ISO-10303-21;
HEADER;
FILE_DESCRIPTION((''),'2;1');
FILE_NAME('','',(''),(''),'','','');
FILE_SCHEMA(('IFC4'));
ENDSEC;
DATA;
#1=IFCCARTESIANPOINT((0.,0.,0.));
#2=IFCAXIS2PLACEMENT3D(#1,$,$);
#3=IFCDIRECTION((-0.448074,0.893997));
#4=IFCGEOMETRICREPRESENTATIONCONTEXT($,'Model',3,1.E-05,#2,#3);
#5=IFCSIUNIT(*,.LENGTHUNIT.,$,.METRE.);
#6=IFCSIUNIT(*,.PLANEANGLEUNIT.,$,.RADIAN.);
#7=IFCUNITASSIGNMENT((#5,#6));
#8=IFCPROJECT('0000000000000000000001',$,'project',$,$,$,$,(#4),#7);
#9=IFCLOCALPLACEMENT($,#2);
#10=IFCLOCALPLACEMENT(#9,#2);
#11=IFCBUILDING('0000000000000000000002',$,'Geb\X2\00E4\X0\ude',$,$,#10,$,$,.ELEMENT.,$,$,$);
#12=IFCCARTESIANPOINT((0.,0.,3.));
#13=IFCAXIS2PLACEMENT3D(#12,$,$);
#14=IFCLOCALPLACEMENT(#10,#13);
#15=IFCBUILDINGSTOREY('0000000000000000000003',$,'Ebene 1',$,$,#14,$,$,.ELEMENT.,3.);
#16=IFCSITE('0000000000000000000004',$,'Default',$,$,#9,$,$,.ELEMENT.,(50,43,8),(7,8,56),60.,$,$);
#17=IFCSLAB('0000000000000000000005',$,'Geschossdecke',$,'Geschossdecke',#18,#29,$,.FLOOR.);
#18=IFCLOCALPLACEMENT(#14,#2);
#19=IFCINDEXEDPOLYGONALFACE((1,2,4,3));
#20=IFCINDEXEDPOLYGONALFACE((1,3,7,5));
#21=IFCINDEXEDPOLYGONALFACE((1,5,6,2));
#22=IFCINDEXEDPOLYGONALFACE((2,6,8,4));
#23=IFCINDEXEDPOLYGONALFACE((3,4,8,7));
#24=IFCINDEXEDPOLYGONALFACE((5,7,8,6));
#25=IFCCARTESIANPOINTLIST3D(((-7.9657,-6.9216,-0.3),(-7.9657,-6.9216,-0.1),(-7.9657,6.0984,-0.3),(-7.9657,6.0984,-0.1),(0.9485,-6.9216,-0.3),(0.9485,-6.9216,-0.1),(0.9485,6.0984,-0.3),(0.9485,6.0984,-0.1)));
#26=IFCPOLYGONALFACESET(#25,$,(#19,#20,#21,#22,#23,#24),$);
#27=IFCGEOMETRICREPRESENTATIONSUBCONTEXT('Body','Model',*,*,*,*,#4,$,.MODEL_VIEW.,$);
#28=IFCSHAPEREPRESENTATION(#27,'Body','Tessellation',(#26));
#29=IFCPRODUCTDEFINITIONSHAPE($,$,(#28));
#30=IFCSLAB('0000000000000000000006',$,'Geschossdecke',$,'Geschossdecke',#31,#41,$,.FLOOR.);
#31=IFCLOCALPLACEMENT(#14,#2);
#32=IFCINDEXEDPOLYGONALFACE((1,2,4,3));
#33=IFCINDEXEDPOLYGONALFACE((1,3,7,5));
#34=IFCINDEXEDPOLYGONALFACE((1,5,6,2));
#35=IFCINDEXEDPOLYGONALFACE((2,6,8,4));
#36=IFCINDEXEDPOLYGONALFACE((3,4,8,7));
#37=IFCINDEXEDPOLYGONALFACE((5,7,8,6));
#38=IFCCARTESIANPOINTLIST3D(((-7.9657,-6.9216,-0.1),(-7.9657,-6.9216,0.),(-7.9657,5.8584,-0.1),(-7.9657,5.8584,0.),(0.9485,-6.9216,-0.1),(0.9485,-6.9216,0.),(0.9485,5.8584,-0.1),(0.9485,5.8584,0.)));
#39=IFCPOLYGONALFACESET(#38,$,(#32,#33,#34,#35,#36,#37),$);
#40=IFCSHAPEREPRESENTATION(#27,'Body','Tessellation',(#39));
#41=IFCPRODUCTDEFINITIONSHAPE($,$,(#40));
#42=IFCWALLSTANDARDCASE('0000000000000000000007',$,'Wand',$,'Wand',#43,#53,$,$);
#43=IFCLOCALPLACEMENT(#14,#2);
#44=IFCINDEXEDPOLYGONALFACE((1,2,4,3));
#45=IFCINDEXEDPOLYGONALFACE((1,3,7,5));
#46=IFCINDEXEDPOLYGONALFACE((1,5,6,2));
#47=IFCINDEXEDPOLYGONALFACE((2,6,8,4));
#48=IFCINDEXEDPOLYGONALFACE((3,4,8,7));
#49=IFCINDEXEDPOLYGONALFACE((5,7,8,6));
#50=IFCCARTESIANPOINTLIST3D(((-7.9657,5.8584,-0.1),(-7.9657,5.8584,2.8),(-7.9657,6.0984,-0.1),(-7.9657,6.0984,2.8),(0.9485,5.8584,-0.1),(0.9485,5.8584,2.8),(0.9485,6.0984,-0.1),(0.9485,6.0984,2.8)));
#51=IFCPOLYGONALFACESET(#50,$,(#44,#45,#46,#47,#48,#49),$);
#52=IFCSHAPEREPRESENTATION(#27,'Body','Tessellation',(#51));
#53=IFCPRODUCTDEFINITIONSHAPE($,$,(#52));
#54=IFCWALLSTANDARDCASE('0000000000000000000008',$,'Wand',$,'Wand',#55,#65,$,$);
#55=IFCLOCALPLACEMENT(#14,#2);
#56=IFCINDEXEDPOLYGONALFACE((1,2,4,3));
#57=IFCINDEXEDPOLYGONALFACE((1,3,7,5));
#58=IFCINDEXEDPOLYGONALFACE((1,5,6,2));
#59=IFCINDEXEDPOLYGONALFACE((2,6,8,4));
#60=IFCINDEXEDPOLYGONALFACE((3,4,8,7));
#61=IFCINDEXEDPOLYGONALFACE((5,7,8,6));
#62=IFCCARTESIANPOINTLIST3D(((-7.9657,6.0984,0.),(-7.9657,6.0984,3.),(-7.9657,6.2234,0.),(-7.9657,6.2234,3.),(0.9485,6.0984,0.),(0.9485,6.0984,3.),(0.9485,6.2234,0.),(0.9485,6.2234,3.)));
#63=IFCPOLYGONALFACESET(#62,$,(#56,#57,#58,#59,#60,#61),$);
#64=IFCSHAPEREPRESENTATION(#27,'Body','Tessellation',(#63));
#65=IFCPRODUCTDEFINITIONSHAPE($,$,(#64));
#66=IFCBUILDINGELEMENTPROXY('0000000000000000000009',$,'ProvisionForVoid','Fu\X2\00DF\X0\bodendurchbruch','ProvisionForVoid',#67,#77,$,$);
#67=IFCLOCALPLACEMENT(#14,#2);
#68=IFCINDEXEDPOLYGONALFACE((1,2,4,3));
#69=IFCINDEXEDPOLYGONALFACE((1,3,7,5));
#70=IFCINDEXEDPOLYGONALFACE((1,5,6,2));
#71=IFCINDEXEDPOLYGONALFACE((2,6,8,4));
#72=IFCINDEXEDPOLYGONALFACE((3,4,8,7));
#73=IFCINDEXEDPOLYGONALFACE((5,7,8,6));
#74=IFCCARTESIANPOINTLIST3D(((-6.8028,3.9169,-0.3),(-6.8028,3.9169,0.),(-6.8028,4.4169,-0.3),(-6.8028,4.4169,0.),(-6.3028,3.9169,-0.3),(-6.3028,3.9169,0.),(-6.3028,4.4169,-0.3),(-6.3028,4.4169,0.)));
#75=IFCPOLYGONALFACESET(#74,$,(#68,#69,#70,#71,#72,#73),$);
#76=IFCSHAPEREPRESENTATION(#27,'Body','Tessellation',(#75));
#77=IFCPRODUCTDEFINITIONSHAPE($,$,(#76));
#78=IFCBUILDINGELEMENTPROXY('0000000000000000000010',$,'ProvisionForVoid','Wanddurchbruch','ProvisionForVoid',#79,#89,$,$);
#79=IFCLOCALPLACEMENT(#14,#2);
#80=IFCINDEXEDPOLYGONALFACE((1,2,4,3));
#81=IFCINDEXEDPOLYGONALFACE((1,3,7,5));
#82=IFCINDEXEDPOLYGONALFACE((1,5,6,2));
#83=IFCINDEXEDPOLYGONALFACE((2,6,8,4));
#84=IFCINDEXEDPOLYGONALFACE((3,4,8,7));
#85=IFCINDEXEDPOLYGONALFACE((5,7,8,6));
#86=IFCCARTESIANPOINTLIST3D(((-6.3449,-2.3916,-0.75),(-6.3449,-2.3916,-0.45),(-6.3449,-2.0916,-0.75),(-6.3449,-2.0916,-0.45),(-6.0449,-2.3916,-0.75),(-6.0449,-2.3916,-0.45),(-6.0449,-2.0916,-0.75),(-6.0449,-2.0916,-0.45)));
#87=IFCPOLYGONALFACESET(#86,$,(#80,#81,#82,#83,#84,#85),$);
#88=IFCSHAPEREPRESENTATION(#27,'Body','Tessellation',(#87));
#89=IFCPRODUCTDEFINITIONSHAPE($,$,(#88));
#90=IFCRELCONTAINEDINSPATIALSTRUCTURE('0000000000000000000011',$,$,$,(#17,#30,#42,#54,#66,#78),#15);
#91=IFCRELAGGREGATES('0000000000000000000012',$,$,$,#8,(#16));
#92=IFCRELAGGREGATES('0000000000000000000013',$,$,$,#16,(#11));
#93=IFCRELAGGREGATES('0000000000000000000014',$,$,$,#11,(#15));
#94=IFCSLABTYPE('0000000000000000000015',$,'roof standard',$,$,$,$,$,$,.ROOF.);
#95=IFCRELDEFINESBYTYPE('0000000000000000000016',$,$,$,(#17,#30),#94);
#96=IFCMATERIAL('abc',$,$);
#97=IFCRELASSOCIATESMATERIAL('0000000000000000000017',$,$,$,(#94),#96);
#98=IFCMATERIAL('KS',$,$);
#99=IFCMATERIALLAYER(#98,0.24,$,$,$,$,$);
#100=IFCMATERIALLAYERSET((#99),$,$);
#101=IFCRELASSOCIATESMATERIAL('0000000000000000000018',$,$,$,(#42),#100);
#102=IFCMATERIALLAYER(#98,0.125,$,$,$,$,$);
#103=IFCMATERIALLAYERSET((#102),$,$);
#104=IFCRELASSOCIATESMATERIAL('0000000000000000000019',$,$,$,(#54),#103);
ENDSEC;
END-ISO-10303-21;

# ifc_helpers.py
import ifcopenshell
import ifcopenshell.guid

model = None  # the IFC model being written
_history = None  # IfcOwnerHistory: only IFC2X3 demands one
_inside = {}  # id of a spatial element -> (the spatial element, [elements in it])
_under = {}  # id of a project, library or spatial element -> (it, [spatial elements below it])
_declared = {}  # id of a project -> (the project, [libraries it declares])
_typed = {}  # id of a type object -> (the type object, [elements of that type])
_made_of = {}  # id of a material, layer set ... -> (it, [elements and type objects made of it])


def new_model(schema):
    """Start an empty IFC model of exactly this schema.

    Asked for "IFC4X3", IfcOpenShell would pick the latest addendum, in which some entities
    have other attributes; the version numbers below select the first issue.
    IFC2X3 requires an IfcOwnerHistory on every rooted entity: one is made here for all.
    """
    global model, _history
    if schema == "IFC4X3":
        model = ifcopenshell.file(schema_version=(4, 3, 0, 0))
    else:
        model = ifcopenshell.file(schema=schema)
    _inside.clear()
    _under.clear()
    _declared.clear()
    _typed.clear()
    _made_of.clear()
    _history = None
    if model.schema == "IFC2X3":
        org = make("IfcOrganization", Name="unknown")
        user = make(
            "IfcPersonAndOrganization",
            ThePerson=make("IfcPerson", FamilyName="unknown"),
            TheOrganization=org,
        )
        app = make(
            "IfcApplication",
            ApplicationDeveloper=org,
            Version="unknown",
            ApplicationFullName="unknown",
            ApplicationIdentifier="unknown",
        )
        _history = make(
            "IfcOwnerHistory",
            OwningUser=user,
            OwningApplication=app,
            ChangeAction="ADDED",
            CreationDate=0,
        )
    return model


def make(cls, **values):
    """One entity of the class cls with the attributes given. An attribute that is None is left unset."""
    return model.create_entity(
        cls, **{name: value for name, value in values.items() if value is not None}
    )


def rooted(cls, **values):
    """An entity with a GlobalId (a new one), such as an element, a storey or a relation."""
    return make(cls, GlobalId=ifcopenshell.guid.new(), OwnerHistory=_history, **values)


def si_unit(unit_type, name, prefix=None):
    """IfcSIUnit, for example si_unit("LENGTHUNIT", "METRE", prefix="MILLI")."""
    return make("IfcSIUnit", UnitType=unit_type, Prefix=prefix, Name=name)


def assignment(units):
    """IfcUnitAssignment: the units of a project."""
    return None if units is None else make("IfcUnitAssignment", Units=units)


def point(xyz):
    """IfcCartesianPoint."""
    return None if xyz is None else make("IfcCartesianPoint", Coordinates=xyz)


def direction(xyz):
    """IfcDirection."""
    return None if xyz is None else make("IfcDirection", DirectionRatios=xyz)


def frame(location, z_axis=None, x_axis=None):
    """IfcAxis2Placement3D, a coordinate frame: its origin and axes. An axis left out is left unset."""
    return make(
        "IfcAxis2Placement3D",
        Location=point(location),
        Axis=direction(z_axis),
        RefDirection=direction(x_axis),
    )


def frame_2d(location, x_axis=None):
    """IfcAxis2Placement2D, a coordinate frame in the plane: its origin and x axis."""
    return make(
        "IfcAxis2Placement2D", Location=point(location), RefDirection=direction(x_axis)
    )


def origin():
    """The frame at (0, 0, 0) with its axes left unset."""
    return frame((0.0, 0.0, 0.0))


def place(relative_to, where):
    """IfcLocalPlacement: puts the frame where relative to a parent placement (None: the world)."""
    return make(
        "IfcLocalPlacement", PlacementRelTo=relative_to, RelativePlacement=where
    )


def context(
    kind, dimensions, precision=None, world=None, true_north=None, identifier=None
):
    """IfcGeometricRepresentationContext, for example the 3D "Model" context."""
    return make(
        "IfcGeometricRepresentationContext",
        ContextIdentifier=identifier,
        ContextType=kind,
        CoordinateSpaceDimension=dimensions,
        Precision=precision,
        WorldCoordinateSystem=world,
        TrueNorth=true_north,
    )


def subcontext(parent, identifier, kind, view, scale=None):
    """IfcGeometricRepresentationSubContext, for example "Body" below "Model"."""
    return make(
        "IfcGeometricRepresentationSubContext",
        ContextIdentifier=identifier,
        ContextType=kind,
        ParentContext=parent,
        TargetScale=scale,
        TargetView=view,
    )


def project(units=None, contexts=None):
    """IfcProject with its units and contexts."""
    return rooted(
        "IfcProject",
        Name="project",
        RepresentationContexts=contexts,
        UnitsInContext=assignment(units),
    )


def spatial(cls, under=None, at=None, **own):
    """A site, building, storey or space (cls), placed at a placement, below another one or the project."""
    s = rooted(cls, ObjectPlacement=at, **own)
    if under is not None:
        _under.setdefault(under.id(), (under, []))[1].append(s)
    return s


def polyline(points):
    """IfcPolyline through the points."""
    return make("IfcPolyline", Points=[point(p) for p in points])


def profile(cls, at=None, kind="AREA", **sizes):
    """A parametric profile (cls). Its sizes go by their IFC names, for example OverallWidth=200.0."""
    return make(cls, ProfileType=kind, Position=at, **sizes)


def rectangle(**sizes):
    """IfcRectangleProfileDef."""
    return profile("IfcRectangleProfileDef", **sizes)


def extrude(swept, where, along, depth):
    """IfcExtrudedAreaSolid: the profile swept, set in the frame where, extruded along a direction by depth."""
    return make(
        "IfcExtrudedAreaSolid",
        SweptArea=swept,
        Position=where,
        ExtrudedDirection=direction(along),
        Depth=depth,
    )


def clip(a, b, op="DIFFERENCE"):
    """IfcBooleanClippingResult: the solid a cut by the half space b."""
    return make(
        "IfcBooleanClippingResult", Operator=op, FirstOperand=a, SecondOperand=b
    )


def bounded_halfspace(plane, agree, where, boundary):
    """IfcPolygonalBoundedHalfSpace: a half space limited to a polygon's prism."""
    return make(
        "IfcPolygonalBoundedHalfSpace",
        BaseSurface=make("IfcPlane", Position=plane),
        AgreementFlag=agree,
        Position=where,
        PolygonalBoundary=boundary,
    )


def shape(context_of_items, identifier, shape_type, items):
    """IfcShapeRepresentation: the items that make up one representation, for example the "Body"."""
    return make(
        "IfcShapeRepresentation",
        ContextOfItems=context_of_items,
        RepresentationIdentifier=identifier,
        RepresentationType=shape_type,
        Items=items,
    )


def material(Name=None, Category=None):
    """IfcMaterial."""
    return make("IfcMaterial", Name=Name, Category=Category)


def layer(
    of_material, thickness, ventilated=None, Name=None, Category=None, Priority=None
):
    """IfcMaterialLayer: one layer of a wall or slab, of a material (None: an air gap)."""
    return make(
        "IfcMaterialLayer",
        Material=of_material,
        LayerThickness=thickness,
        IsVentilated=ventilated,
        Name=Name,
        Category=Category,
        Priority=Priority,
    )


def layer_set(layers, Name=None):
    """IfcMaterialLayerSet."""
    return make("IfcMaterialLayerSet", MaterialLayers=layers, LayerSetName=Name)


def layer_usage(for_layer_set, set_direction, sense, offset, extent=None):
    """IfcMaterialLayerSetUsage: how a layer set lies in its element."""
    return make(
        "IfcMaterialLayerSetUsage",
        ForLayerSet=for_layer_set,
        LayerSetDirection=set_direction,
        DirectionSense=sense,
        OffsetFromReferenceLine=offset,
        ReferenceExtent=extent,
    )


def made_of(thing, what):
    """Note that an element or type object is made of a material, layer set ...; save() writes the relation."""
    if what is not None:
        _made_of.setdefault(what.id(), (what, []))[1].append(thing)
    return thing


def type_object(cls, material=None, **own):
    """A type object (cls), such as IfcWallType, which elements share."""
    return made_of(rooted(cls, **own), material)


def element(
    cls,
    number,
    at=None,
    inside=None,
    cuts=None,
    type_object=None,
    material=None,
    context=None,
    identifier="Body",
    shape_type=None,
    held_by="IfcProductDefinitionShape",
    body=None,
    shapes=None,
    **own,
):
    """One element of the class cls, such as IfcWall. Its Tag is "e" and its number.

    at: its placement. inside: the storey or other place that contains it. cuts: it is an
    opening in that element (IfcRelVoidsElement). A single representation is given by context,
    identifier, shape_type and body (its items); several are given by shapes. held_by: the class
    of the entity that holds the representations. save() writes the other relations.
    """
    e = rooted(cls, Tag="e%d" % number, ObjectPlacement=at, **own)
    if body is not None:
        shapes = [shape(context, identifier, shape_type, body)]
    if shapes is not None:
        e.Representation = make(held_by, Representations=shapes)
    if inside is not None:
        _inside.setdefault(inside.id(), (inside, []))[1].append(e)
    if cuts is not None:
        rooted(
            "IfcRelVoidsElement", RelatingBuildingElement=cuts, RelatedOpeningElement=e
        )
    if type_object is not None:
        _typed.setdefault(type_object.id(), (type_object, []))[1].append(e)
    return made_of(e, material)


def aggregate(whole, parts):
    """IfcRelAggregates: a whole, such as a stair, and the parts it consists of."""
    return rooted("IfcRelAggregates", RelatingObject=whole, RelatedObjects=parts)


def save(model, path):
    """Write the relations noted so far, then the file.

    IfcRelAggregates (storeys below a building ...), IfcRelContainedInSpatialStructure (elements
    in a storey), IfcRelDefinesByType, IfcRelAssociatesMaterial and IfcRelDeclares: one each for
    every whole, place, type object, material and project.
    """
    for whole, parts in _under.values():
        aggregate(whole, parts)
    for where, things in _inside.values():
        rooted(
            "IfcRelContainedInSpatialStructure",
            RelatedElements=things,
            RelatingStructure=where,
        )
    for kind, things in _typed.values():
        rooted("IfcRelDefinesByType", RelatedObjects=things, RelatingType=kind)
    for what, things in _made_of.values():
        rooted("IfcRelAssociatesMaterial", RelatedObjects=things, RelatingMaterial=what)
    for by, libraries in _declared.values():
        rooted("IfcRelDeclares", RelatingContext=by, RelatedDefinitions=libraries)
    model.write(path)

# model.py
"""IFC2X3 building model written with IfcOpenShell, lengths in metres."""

from ifc_helpers import new_model, si_unit, direction, frame, frame_2d, origin, place, context, subcontext, project, spatial, polyline, rectangle, extrude, clip, bounded_halfspace, material, layer, layer_set, layer_usage, type_object, element, save


model = new_model("IFC2X3")

# Units and contexts
model_context = context("Model", 3, precision=1e-05, world=origin(), true_north=direction((-0.448074, 0.893997)))
body_context = subcontext(model_context, "Body", "Model", "MODEL_VIEW")
ifc_project = project(units=[si_unit("LENGTHUNIT", "METRE"), si_unit("PLANEANGLEUNIT", "RADIAN")], contexts=[model_context])

# Site, building, storey
site_placement = place(None, origin())
site = spatial("IfcSite", under=ifc_project, at=site_placement, Name="Default", CompositionType="ELEMENT", RefLatitude=(50, 43, 8), RefLongitude=(7, 8, 56), RefElevation=60.0)
building_placement = place(site_placement, origin())
building = spatial("IfcBuilding", under=site, at=building_placement, Name="Gebäude", CompositionType="ELEMENT")
storey_placement = place(building_placement, frame((0.0, 0.0, 3.0)))
storey = spatial("IfcBuildingStorey", under=building, at=storey_placement, Name="Ebene 1", CompositionType="ELEMENT", Elevation=3.0)

# Slabs
ifc_material_1 = material(Name="abc")
slab_type = type_object("IfcSlabType", Name="roof standard", PredefinedType="ROOF", material=ifc_material_1)
slab_1_placement = place(storey_placement, frame((0.0, 0.0, -0.1)))
element("IfcSlab", 1, at=slab_1_placement, inside=storey, type_object=slab_type, Name="Geschossdecke", ObjectType="Geschossdecke", PredefinedType="FLOOR", context=body_context, shape_type="SweptSolid", body=[
    extrude(rectangle(XDim=8.9141, YDim=13.02, at=frame_2d((0.0, 0.0), x_axis=(1.0, 0.0))), frame((-3.5086, -0.4116, -0.2)), (0.0, 0.0, 1.0), 0.2),
])
slab_2_placement = place(storey_placement, origin())
element("IfcSlab", 2, at=slab_2_placement, inside=storey, type_object=slab_type, Name="Geschossdecke", ObjectType="Geschossdecke", PredefinedType="FLOOR", context=body_context, shape_type="SweptSolid", body=[
    extrude(rectangle(XDim=8.9141, YDim=12.78, at=frame_2d((0.0, 0.0), x_axis=(1.0, 0.0))), frame((-3.5086, -0.5316, -0.1)), (0.0, 0.0, 1.0), 0.1),
])

# Walls
ifc_material_2 = material(Name="KS")
ifc_layer_1 = layer(ifc_material_2, 0.24)
ifc_layer_set_1 = layer_set([ifc_layer_1])
ifc_layer_usage_1 = layer_usage(ifc_layer_set_1, "AXIS2", "POSITIVE", -0.12)
wall_1_placement = place(storey_placement, frame((-7.9657, 5.9784, 0.0)))
element("IfcWallStandardCase", 3, at=wall_1_placement, inside=storey, material=ifc_layer_usage_1, Name="Wand", ObjectType="Wand", context=body_context, shape_type="Clipping", body=[
    clip(clip(extrude(rectangle(XDim=8.9141, YDim=0.24, at=frame_2d((0.0, 0.0), x_axis=(1.0, 0.0))), frame((4.4571, 0.0, -0.1)), (0.0, 0.0, 1.0), 2.9), bounded_halfspace(frame((0.0, -0.12, 2.8)), False, origin(), polyline([(0.0, -0.12), (8.9141, -0.12), (8.9141, 0.12), (0.0, 0.12), (0.0, -0.12)]))), bounded_halfspace(frame((0.0, 0.12, -0.1), z_axis=(0.0, 0.0, -1.0), x_axis=(1.0, 0.0, 0.0)), False, origin(), polyline([(0.0, 0.12), (8.9141, 0.12), (8.9141, -0.12), (0.0, -0.12), (0.0, 0.12)]))),
])
ifc_layer_2 = layer(ifc_material_2, 0.125)
ifc_layer_set_2 = layer_set([ifc_layer_2])
ifc_layer_usage_2 = layer_usage(ifc_layer_set_2, "AXIS2", "POSITIVE", -0.0625)
wall_2_placement = place(storey_placement, frame((-7.9657, 6.1609, 0.0)))
element("IfcWallStandardCase", 4, at=wall_2_placement, inside=storey, material=ifc_layer_usage_2, Name="Wand", ObjectType="Wand", context=body_context, shape_type="Clipping", body=[
    clip(clip(extrude(rectangle(XDim=8.9141, YDim=0.125, at=frame_2d((0.0, 0.0), x_axis=(1.0, 0.0))), frame((4.4571, 0.0, 0.0)), (0.0, 0.0, 1.0), 3.0), bounded_halfspace(frame((0.0, -0.0625, 3.0)), False, origin(), polyline([(0.0, -0.0625), (8.9141, -0.0625), (8.9141, 0.0625), (0.0, 0.0625), (0.0, -0.0625)]))), bounded_halfspace(frame((0.0, 0.0625, 0.0), z_axis=(0.0, 0.0, -1.0), x_axis=(1.0, 0.0, 0.0)), False, origin(), polyline([(0.0, 0.0625), (8.9141, 0.0625), (8.9141, -0.0625), (0.0, -0.0625), (0.0, 0.0625)]))),
])

# Building element proxies
proxy_1_placement = place(storey_placement, origin())
element("IfcBuildingElementProxy", 5, at=proxy_1_placement, inside=storey, Name="ProvisionForVoid", Description="Fußbodendurchbruch", ObjectType="ProvisionForVoid", context=body_context, shape_type="SweptSolid", body=[
    extrude(rectangle(XDim=0.5, YDim=0.3, at=frame_2d((0.0, 0.0), x_axis=(1.0, 0.0))), frame((-6.8028, 4.1669, -0.15), z_axis=(1.0, 0.0, 0.0), x_axis=(0.0, 1.0, 0.0)), (0.0, 0.0, 1.0), 0.5),
])
proxy_2_placement = place(storey_placement, origin())
element("IfcBuildingElementProxy", 6, at=proxy_2_placement, inside=storey, Name="ProvisionForVoid", Description="Wanddurchbruch", ObjectType="ProvisionForVoid", context=body_context, shape_type="SweptSolid", body=[
    extrude(rectangle(XDim=0.3, YDim=0.3, at=frame_2d((0.0, 0.0), x_axis=(1.0, 0.0))), frame((-6.1949, -2.0916, -0.6), z_axis=(0.0, -1.0, 0.0), x_axis=(1.0, 0.0, 0.0)), (0.0, 0.0, 1.0), 0.3),
])

save(model, "model.ifc")
